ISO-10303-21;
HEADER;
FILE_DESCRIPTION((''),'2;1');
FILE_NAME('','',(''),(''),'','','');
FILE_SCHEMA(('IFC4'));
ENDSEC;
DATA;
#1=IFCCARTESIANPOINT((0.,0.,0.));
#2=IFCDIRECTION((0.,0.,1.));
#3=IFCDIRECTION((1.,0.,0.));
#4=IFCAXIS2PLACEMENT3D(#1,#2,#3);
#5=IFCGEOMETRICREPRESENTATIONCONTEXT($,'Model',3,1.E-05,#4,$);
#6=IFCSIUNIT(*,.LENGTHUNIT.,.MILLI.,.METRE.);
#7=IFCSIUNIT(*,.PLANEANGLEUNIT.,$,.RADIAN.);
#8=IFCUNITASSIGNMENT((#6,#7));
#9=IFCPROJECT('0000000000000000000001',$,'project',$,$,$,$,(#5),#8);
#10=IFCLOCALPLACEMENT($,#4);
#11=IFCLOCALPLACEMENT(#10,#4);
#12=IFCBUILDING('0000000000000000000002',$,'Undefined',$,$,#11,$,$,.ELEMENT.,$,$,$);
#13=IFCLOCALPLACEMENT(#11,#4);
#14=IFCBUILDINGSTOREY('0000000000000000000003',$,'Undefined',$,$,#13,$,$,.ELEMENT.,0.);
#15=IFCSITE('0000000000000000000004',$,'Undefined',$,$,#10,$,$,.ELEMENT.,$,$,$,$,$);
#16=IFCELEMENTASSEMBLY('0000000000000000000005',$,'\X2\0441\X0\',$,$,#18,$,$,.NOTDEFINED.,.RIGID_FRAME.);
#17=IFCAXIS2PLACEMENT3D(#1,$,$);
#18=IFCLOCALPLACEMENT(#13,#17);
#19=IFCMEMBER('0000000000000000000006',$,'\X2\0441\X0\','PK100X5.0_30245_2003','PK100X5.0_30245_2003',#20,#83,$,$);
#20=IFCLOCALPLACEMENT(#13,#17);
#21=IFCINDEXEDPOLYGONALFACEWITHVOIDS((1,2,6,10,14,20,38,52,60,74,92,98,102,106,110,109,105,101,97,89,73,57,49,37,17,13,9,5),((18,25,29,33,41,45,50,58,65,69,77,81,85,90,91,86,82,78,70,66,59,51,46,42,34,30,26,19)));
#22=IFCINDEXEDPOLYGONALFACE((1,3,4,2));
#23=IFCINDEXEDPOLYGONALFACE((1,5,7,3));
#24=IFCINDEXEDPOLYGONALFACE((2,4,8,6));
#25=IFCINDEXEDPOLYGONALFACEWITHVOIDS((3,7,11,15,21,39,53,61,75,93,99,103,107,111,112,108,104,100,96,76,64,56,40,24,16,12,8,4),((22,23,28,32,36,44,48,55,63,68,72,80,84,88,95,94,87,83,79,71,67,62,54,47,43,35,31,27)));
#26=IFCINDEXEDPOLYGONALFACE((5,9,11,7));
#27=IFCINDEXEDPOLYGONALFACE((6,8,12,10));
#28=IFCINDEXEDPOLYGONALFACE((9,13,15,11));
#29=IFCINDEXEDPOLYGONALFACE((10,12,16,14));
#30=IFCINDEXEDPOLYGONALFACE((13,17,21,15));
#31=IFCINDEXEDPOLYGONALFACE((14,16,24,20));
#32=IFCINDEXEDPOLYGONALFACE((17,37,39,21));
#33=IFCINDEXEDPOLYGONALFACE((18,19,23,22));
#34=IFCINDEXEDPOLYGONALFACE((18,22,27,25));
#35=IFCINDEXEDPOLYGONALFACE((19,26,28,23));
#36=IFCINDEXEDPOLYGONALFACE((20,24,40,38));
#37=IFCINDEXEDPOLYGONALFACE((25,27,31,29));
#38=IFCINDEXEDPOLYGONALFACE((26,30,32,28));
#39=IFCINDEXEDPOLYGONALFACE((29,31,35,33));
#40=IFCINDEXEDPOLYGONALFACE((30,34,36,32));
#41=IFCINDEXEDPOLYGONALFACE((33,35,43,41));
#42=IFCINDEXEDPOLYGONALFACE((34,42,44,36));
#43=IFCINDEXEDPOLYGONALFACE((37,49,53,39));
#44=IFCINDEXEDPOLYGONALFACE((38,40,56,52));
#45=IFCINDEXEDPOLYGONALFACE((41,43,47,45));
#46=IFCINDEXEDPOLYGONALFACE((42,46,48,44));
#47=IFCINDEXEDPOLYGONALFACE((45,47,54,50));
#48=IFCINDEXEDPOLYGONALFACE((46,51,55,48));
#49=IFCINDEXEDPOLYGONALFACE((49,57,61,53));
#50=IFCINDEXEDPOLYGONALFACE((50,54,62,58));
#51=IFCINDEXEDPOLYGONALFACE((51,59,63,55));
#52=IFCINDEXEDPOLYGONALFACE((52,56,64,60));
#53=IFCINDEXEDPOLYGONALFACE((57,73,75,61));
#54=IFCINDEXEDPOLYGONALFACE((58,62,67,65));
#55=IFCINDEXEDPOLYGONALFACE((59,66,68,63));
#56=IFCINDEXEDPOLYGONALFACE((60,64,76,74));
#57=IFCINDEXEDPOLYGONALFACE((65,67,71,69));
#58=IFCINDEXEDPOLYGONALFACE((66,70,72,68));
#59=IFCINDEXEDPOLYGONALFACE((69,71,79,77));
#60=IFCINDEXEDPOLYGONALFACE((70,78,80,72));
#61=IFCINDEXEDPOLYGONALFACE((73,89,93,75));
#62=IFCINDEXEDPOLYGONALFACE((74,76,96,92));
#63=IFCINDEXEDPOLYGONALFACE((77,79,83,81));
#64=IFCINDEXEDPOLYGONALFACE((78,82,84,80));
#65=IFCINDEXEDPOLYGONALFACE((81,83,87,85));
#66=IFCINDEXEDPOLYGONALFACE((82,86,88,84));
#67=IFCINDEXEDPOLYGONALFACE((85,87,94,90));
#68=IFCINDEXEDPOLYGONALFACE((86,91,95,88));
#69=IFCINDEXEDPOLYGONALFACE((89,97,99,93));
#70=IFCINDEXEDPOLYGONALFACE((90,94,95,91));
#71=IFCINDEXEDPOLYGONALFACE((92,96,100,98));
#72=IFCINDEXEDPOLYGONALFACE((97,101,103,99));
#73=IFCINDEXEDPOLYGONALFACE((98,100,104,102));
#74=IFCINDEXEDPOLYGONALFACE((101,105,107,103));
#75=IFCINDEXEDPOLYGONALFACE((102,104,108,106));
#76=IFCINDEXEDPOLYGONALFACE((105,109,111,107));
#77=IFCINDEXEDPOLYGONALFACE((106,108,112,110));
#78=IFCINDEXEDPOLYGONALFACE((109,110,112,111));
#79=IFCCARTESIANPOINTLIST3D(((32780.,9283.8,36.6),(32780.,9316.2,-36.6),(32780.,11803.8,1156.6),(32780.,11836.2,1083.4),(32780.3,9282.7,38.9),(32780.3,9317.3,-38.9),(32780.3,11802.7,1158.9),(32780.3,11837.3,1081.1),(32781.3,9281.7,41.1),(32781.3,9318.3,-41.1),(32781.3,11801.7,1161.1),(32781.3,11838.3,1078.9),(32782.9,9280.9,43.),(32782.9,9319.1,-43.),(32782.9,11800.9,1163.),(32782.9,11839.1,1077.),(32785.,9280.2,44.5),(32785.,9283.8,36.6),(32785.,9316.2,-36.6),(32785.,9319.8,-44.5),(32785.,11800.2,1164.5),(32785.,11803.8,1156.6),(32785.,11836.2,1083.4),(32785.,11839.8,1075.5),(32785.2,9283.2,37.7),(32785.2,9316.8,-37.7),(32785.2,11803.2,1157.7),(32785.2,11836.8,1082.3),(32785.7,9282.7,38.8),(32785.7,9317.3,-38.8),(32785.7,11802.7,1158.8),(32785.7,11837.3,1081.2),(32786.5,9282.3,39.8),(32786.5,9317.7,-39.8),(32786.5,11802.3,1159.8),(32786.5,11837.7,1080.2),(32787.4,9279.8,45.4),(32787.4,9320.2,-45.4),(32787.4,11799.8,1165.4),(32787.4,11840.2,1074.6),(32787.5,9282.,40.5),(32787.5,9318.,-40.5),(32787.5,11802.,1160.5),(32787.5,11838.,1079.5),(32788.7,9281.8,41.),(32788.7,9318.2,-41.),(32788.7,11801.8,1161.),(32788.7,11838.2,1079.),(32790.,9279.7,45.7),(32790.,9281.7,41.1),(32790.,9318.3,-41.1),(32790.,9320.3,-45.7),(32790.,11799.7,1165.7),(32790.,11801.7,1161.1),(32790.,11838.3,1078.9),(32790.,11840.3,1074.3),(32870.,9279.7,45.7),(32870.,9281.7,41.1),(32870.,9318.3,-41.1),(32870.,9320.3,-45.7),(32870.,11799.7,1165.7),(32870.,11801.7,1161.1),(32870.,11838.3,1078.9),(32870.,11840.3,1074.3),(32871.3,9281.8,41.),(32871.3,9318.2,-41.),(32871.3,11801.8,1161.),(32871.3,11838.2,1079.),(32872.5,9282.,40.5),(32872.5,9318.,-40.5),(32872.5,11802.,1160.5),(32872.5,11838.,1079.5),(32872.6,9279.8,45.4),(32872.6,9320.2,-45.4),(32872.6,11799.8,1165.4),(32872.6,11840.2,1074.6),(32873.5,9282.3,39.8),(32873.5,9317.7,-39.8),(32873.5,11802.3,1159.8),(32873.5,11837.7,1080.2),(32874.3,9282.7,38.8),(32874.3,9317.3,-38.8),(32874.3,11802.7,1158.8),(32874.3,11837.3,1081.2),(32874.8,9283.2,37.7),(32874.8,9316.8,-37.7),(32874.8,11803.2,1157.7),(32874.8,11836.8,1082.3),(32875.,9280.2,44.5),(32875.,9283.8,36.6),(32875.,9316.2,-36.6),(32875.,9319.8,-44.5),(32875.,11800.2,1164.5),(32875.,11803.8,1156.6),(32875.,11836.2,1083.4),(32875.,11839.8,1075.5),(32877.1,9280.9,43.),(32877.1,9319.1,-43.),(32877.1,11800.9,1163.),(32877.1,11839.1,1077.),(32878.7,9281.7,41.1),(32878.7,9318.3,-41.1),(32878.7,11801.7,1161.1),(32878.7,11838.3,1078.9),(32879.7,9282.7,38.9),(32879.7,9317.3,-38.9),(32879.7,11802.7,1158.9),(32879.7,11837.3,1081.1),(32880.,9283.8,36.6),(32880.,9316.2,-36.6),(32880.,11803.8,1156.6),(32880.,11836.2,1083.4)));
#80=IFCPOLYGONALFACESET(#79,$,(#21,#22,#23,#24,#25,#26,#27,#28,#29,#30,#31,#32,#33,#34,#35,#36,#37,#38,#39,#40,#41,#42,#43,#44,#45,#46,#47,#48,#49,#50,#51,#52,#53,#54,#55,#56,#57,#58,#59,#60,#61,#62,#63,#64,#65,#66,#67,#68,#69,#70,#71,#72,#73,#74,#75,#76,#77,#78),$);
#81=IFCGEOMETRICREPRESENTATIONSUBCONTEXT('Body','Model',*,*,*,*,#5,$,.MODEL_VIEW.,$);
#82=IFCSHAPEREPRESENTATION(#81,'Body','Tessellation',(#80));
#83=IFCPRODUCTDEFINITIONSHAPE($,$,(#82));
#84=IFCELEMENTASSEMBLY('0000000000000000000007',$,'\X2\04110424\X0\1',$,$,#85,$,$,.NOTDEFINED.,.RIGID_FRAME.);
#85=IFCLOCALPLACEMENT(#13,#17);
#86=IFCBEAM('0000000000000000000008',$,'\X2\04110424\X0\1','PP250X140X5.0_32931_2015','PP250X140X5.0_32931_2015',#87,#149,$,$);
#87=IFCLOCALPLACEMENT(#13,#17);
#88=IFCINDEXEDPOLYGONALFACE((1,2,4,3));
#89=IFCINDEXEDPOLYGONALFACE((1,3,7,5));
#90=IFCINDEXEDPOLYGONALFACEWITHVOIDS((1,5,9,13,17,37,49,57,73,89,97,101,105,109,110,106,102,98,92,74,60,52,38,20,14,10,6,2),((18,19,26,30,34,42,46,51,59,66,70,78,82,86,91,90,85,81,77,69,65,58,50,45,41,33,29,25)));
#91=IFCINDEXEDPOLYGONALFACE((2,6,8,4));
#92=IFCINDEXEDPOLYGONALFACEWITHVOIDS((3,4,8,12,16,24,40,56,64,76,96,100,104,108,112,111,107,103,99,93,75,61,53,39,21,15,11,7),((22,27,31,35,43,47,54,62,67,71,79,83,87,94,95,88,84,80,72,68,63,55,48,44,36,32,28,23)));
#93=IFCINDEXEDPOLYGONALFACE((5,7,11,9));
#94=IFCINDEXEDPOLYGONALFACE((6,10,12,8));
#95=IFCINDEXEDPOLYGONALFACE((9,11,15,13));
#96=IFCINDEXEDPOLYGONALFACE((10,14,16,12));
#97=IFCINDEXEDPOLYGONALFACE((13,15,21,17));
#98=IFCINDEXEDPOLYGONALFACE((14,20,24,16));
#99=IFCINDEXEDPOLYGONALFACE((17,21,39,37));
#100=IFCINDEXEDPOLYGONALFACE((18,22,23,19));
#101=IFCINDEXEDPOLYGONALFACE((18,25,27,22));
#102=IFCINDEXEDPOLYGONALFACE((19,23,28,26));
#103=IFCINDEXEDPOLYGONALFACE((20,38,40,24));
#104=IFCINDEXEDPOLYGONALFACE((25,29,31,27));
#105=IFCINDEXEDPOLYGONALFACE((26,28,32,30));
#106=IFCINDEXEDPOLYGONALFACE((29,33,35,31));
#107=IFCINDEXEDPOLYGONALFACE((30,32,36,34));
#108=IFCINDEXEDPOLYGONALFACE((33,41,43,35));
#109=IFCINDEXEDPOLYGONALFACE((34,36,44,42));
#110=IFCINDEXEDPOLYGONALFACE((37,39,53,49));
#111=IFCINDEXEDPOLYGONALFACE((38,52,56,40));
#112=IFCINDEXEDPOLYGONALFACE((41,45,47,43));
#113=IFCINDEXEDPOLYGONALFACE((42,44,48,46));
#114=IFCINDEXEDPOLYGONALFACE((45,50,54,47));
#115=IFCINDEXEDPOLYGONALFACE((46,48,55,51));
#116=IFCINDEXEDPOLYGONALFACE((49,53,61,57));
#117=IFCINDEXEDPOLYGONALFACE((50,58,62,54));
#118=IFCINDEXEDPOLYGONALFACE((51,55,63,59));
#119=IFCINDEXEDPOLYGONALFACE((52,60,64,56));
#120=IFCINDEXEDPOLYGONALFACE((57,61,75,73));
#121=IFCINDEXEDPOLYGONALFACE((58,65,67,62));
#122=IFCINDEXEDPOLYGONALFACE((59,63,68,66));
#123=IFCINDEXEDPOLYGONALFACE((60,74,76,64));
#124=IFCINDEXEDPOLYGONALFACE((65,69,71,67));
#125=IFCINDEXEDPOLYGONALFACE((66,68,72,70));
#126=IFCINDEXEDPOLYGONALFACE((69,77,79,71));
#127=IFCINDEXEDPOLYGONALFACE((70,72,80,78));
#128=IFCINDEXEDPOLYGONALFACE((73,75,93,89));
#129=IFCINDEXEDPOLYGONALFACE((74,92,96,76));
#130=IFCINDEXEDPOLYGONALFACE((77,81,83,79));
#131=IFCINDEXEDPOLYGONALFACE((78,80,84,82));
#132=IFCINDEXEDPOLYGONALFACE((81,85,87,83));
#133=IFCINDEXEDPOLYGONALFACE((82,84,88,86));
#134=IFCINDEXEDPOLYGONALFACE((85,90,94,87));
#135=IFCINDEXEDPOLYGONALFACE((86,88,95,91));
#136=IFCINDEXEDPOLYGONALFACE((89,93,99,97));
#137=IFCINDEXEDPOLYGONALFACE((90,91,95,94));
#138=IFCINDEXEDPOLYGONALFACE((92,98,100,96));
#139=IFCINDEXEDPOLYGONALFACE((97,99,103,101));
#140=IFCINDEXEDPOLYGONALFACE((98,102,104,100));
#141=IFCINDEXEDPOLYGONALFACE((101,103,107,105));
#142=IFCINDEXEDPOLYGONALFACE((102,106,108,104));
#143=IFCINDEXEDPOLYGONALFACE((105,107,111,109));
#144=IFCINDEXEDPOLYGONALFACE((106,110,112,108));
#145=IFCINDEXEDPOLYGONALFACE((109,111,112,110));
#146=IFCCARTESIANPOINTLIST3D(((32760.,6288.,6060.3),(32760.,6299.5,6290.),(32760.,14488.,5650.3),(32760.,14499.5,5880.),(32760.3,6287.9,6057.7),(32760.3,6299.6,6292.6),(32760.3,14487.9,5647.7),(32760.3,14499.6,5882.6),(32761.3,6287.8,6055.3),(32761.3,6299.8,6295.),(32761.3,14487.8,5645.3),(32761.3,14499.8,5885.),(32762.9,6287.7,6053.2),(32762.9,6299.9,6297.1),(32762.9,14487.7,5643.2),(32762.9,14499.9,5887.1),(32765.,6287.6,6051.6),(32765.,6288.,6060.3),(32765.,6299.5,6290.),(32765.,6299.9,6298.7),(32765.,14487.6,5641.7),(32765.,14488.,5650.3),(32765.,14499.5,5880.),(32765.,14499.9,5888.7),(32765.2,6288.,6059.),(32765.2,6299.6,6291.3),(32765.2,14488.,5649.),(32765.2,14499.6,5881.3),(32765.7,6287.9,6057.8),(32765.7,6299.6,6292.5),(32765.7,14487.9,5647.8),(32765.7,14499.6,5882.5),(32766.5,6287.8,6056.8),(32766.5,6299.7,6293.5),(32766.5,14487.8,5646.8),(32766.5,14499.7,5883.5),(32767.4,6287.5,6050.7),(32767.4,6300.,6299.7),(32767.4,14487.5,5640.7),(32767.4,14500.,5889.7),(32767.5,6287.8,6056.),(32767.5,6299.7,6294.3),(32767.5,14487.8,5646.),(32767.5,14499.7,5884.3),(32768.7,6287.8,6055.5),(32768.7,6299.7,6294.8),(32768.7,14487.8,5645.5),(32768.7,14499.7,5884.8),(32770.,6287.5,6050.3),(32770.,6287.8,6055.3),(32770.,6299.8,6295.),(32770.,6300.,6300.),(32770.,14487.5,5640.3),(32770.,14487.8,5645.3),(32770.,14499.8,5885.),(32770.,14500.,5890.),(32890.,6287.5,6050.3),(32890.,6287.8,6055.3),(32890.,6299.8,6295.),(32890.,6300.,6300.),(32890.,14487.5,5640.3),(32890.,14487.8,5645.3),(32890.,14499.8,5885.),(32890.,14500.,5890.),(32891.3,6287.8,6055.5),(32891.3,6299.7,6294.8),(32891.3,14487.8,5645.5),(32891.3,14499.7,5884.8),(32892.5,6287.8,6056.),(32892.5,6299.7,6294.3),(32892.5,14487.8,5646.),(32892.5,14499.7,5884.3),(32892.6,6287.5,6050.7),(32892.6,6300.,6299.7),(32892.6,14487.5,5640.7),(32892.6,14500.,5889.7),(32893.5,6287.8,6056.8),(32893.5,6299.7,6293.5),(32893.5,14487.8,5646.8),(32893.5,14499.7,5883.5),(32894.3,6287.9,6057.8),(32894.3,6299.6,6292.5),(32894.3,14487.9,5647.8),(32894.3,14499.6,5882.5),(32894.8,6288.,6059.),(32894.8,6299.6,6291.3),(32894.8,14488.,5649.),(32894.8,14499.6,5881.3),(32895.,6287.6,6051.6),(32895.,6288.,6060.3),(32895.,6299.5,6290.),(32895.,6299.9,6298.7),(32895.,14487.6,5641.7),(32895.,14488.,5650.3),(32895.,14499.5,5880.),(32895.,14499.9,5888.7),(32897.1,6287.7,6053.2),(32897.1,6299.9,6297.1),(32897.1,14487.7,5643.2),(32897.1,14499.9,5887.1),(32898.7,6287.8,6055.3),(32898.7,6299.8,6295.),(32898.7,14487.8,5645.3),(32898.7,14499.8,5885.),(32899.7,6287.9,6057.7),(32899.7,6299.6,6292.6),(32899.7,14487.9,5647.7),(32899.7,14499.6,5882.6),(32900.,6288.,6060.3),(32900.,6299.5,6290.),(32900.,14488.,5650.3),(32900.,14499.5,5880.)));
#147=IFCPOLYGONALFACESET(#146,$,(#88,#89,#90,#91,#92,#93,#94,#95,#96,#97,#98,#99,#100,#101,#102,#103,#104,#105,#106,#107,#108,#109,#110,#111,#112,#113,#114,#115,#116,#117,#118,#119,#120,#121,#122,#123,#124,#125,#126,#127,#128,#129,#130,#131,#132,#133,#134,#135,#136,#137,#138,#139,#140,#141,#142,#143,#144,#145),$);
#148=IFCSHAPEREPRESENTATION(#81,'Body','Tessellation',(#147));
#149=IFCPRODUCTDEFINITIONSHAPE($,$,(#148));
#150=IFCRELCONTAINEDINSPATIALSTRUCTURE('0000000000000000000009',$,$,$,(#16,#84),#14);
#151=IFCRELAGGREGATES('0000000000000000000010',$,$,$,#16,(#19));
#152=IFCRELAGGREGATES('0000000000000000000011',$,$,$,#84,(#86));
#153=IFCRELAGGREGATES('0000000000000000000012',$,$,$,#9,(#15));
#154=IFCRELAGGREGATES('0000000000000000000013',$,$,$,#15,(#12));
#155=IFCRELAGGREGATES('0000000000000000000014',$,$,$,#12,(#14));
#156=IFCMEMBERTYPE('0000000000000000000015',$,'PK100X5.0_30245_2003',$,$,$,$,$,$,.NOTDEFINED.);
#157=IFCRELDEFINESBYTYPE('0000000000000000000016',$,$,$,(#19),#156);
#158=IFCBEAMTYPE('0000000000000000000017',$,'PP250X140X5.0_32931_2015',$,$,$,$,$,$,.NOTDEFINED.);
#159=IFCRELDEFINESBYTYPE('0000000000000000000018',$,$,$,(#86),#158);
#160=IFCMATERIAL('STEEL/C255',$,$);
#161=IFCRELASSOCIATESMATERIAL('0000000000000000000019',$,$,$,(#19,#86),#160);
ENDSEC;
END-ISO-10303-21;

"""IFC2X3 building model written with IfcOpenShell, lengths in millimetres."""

from ifc_helpers import new_model, si_unit, frame, origin_with_axes, origin_2d_with_axis, place, context, subcontext, project, spatial, hollow_rectangle, extrude, material, type_object, element, aggregate, save


model = new_model("IFC2X3")

# Units and contexts
model_context = context("Model", 3, precision=1e-05, world=origin_with_axes())
body_context = subcontext(model_context, "Body", "Model", "MODEL_VIEW")
ifc_project = project(units=[si_unit("LENGTHUNIT", "METRE", prefix="MILLI"), si_unit("PLANEANGLEUNIT", "RADIAN")], contexts=[model_context])

# Site, building, storey
site_placement = place(None, origin_with_axes())
site = spatial("IfcSite", under=ifc_project, at=site_placement, Name="Undefined", CompositionType="ELEMENT")
building_placement = place(site_placement, origin_with_axes())
building = spatial("IfcBuilding", under=site, at=building_placement, Name="Undefined", CompositionType="ELEMENT")
storey_placement = place(building_placement, origin_with_axes())
storey = spatial("IfcBuildingStorey", under=building, at=storey_placement, Name="Undefined", CompositionType="ELEMENT", Elevation=0.0)

# Shared definitions
ifc_material_1 = material(Name="STEEL/C255")

# Element assembly, member
member_type = type_object("IfcMemberType", Name="PK100X5.0_30245_2003", PredefinedType="NOTDEFINED")
assembly_1_placement = place(storey_placement, origin_with_axes())
assembly_1 = element("IfcElementAssembly", 1, at=assembly_1_placement, inside=storey, Name="с", AssemblyPlace="NOTDEFINED", PredefinedType="RIGID_FRAME")
member_1_placement = place(assembly_1_placement, frame((32830.0, 9300.0, 0.0), z_axis=(-1.0, 0.0, 0.0), x_axis=(0.0, 0.913812, 0.406138)))
member_1 = element("IfcMember", 2, at=member_1_placement, type_object=member_type, material=ifc_material_1, Name="с", Description="PK100X5.0_30245_2003", ObjectType="PK100X5.0_30245_2003", context=body_context, shape_type="SweptSolid", body=[
    extrude(hollow_rectangle(XDim=100.0, YDim=100.0, WallThickness=5.0, InnerFilletRadius=5.0, OuterFilletRadius=10.0, at=origin_2d_with_axis()), frame((2757.7, 0.0, 0.0), z_axis=(-1.0, 0.0, 0.0), x_axis=(0.0, -1.0, 0.0)), (0.0, 0.0, 1.0), 2757.7),
])
aggregate(assembly_1, [member_1])

# Element assembly, beam
assembly_2_placement = place(storey_placement, origin_with_axes())
assembly_2 = element("IfcElementAssembly", 3, at=assembly_2_placement, inside=storey, Name="БФ1", AssemblyPlace="NOTDEFINED", PredefinedType="RIGID_FRAME")
beam_type_1 = type_object("IfcBeamType", Name="PP250X140X5.0_32931_2015", PredefinedType="NOTDEFINED")
beam_1_placement = place(assembly_2_placement, frame((32830.0, 6293.8, 6175.2), z_axis=(0.0, -0.049938, -0.998752), x_axis=(0.0, 0.998752, -0.049938)))
beam_1 = element("IfcBeam", 4, at=beam_1_placement, type_object=beam_type_1, material=ifc_material_1, Name="БФ1", Description="PP250X140X5.0_32931_2015", ObjectType="PP250X140X5.0_32931_2015", context=body_context, shape_type="SweptSolid", body=[
    extrude(hollow_rectangle(XDim=140.0, YDim=250.0, WallThickness=5.0, InnerFilletRadius=5.0, OuterFilletRadius=10.0, at=origin_2d_with_axis()), frame((8210.2, 0.0, 0.0), z_axis=(-1.0, 0.0, 0.0), x_axis=(0.0, -1.0, 0.0)), (0.0, 0.0, 1.0), 8210.2),
])
aggregate(assembly_2, [beam_1])

save(model, "model.ifc")
